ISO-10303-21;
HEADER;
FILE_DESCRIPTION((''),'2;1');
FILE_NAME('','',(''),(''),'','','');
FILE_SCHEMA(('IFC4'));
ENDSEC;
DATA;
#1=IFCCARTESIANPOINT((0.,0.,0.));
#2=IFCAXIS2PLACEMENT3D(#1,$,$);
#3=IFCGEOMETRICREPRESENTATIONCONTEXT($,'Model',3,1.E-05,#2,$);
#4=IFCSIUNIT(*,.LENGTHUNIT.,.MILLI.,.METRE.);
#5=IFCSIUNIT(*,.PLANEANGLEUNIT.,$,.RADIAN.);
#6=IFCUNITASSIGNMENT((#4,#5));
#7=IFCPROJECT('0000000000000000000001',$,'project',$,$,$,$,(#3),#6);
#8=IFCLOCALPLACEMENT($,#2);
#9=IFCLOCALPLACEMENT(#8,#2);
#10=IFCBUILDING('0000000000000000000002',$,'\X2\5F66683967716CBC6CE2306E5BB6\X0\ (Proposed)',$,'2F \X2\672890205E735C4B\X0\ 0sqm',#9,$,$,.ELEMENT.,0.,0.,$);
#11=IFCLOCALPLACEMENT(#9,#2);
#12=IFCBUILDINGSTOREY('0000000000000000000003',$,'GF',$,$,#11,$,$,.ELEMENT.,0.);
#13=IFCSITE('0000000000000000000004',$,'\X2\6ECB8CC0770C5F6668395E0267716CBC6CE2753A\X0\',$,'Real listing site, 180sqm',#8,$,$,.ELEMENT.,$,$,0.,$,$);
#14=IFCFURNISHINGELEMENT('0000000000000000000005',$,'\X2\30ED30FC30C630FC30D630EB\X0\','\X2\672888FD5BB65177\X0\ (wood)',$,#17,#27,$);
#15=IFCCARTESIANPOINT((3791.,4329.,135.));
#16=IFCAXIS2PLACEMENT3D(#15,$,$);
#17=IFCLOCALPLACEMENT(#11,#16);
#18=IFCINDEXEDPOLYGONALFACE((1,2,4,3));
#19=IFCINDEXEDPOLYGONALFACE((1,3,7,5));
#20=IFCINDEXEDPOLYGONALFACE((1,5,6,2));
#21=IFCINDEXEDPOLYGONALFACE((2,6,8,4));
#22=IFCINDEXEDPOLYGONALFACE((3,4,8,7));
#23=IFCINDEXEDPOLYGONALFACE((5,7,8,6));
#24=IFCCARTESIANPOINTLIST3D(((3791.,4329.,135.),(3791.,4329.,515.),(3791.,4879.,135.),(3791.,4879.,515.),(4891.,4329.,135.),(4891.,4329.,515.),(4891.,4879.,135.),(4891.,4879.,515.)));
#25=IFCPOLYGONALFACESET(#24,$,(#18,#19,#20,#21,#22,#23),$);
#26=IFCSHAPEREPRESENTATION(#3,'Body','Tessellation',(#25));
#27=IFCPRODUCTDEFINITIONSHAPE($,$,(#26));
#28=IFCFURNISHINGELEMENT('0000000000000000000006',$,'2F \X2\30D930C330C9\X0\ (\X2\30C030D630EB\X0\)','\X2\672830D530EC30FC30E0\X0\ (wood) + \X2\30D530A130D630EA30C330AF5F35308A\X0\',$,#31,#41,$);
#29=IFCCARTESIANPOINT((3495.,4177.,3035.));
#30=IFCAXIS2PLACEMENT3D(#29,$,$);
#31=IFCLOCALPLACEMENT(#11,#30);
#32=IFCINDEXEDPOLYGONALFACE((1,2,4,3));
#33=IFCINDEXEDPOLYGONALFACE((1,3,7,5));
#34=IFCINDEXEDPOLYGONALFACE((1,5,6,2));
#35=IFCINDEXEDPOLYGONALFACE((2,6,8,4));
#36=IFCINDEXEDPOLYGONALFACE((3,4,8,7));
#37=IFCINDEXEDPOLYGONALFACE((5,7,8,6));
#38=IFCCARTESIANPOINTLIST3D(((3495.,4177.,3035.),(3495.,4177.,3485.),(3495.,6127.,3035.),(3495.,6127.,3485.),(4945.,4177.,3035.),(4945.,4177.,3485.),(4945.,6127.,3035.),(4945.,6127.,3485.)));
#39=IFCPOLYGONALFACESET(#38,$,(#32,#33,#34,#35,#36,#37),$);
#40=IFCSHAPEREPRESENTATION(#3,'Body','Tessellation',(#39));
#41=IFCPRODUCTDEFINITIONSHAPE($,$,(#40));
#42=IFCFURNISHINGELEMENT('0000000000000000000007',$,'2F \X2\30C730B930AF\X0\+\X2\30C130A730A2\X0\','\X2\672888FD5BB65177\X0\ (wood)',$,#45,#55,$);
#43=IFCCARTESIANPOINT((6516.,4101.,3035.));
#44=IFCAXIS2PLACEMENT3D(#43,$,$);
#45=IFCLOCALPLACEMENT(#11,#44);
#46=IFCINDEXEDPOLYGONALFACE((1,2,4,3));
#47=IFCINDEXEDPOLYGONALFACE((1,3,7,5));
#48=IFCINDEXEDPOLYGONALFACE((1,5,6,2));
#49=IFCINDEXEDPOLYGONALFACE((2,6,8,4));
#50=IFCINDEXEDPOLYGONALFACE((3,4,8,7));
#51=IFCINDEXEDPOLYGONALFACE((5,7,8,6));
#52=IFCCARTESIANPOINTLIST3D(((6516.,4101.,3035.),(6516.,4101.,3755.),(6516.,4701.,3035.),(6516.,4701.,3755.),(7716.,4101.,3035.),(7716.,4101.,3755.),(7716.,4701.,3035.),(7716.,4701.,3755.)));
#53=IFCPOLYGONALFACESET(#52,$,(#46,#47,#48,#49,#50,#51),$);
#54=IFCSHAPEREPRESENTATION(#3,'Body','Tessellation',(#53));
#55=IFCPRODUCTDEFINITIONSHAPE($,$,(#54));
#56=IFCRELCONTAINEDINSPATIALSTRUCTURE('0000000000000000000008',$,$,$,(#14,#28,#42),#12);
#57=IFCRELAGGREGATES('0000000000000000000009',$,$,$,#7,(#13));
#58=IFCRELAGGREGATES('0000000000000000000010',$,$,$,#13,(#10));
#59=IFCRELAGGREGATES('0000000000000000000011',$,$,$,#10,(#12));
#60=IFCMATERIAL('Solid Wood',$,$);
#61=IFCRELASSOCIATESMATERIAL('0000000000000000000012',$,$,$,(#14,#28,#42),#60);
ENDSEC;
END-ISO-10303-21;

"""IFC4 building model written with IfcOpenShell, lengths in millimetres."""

from ifc_helpers import new_model, si_unit, frame, frame_2d, origin, place, context, project, spatial, rectangle, extrude, material, element, save


model = new_model("IFC4")

# Units and contexts
model_context = context("Model", 3, precision=1e-05, world=origin())
ifc_project = project(units=[si_unit("LENGTHUNIT", "METRE", prefix="MILLI"), si_unit("PLANEANGLEUNIT", "RADIAN")], contexts=[model_context])

# Site, building, storey
site_placement = place(None, origin())
site = spatial("IfcSite", under=ifc_project, at=site_placement, Name="滋賀県彦根市東沼波町", ObjectType="Real listing site, 180sqm", CompositionType="ELEMENT", RefElevation=0.0)
building_placement = place(site_placement, origin())
building = spatial("IfcBuilding", under=site, at=building_placement, Name="彦根東沼波の家 (Proposed)", ObjectType="2F 木造平屋 0sqm", CompositionType="ELEMENT", ElevationOfRefHeight=0.0, ElevationOfTerrain=0.0)
storey_placement = place(building_placement, origin())
storey = spatial("IfcBuildingStorey", under=building, at=storey_placement, Name="GF", CompositionType="ELEMENT", Elevation=0.0)

# Shared definitions
ifc_material_1 = material(Name="Solid Wood")

# Furnishing elements
furnishing_1_placement = place(storey_placement, frame((3791.0, 4329.0, 135.0)))
element("IfcFurnishingElement", 1, at=furnishing_1_placement, inside=storey, material=ifc_material_1, Name="ローテーブル", Description="木製家具 (wood)", context=model_context, shape_type="SweptSolid", body=[
    extrude(rectangle(XDim=1100.0, YDim=550.0, at=frame_2d((550.0, 275.0))), frame((3791.0, 4329.0, 135.0)), (0.0, 0.0, 1.0), 380.0),
])
furnishing_2_placement = place(storey_placement, frame((3495.0, 4177.0, 3035.0)))
element("IfcFurnishingElement", 2, at=furnishing_2_placement, inside=storey, material=ifc_material_1, Name="2F ベッド (ダブル)", Description="木フレーム (wood) + ファブリック張り", context=model_context, shape_type="SweptSolid", body=[
    extrude(rectangle(XDim=1450.0, YDim=1950.0, at=frame_2d((725.0, 975.0))), frame((3495.0, 4177.0, 3035.0)), (0.0, 0.0, 1.0), 450.0),
])
furnishing_3_placement = place(storey_placement, frame((6516.0, 4101.0, 3035.0)))
element("IfcFurnishingElement", 3, at=furnishing_3_placement, inside=storey, material=ifc_material_1, Name="2F デスク+チェア", Description="木製家具 (wood)", context=model_context, shape_type="SweptSolid", body=[
    extrude(rectangle(XDim=1200.0, YDim=600.0, at=frame_2d((600.0, 300.0))), frame((6516.0, 4101.0, 3035.0)), (0.0, 0.0, 1.0), 720.0),
])

save(model, "model.ifc")
